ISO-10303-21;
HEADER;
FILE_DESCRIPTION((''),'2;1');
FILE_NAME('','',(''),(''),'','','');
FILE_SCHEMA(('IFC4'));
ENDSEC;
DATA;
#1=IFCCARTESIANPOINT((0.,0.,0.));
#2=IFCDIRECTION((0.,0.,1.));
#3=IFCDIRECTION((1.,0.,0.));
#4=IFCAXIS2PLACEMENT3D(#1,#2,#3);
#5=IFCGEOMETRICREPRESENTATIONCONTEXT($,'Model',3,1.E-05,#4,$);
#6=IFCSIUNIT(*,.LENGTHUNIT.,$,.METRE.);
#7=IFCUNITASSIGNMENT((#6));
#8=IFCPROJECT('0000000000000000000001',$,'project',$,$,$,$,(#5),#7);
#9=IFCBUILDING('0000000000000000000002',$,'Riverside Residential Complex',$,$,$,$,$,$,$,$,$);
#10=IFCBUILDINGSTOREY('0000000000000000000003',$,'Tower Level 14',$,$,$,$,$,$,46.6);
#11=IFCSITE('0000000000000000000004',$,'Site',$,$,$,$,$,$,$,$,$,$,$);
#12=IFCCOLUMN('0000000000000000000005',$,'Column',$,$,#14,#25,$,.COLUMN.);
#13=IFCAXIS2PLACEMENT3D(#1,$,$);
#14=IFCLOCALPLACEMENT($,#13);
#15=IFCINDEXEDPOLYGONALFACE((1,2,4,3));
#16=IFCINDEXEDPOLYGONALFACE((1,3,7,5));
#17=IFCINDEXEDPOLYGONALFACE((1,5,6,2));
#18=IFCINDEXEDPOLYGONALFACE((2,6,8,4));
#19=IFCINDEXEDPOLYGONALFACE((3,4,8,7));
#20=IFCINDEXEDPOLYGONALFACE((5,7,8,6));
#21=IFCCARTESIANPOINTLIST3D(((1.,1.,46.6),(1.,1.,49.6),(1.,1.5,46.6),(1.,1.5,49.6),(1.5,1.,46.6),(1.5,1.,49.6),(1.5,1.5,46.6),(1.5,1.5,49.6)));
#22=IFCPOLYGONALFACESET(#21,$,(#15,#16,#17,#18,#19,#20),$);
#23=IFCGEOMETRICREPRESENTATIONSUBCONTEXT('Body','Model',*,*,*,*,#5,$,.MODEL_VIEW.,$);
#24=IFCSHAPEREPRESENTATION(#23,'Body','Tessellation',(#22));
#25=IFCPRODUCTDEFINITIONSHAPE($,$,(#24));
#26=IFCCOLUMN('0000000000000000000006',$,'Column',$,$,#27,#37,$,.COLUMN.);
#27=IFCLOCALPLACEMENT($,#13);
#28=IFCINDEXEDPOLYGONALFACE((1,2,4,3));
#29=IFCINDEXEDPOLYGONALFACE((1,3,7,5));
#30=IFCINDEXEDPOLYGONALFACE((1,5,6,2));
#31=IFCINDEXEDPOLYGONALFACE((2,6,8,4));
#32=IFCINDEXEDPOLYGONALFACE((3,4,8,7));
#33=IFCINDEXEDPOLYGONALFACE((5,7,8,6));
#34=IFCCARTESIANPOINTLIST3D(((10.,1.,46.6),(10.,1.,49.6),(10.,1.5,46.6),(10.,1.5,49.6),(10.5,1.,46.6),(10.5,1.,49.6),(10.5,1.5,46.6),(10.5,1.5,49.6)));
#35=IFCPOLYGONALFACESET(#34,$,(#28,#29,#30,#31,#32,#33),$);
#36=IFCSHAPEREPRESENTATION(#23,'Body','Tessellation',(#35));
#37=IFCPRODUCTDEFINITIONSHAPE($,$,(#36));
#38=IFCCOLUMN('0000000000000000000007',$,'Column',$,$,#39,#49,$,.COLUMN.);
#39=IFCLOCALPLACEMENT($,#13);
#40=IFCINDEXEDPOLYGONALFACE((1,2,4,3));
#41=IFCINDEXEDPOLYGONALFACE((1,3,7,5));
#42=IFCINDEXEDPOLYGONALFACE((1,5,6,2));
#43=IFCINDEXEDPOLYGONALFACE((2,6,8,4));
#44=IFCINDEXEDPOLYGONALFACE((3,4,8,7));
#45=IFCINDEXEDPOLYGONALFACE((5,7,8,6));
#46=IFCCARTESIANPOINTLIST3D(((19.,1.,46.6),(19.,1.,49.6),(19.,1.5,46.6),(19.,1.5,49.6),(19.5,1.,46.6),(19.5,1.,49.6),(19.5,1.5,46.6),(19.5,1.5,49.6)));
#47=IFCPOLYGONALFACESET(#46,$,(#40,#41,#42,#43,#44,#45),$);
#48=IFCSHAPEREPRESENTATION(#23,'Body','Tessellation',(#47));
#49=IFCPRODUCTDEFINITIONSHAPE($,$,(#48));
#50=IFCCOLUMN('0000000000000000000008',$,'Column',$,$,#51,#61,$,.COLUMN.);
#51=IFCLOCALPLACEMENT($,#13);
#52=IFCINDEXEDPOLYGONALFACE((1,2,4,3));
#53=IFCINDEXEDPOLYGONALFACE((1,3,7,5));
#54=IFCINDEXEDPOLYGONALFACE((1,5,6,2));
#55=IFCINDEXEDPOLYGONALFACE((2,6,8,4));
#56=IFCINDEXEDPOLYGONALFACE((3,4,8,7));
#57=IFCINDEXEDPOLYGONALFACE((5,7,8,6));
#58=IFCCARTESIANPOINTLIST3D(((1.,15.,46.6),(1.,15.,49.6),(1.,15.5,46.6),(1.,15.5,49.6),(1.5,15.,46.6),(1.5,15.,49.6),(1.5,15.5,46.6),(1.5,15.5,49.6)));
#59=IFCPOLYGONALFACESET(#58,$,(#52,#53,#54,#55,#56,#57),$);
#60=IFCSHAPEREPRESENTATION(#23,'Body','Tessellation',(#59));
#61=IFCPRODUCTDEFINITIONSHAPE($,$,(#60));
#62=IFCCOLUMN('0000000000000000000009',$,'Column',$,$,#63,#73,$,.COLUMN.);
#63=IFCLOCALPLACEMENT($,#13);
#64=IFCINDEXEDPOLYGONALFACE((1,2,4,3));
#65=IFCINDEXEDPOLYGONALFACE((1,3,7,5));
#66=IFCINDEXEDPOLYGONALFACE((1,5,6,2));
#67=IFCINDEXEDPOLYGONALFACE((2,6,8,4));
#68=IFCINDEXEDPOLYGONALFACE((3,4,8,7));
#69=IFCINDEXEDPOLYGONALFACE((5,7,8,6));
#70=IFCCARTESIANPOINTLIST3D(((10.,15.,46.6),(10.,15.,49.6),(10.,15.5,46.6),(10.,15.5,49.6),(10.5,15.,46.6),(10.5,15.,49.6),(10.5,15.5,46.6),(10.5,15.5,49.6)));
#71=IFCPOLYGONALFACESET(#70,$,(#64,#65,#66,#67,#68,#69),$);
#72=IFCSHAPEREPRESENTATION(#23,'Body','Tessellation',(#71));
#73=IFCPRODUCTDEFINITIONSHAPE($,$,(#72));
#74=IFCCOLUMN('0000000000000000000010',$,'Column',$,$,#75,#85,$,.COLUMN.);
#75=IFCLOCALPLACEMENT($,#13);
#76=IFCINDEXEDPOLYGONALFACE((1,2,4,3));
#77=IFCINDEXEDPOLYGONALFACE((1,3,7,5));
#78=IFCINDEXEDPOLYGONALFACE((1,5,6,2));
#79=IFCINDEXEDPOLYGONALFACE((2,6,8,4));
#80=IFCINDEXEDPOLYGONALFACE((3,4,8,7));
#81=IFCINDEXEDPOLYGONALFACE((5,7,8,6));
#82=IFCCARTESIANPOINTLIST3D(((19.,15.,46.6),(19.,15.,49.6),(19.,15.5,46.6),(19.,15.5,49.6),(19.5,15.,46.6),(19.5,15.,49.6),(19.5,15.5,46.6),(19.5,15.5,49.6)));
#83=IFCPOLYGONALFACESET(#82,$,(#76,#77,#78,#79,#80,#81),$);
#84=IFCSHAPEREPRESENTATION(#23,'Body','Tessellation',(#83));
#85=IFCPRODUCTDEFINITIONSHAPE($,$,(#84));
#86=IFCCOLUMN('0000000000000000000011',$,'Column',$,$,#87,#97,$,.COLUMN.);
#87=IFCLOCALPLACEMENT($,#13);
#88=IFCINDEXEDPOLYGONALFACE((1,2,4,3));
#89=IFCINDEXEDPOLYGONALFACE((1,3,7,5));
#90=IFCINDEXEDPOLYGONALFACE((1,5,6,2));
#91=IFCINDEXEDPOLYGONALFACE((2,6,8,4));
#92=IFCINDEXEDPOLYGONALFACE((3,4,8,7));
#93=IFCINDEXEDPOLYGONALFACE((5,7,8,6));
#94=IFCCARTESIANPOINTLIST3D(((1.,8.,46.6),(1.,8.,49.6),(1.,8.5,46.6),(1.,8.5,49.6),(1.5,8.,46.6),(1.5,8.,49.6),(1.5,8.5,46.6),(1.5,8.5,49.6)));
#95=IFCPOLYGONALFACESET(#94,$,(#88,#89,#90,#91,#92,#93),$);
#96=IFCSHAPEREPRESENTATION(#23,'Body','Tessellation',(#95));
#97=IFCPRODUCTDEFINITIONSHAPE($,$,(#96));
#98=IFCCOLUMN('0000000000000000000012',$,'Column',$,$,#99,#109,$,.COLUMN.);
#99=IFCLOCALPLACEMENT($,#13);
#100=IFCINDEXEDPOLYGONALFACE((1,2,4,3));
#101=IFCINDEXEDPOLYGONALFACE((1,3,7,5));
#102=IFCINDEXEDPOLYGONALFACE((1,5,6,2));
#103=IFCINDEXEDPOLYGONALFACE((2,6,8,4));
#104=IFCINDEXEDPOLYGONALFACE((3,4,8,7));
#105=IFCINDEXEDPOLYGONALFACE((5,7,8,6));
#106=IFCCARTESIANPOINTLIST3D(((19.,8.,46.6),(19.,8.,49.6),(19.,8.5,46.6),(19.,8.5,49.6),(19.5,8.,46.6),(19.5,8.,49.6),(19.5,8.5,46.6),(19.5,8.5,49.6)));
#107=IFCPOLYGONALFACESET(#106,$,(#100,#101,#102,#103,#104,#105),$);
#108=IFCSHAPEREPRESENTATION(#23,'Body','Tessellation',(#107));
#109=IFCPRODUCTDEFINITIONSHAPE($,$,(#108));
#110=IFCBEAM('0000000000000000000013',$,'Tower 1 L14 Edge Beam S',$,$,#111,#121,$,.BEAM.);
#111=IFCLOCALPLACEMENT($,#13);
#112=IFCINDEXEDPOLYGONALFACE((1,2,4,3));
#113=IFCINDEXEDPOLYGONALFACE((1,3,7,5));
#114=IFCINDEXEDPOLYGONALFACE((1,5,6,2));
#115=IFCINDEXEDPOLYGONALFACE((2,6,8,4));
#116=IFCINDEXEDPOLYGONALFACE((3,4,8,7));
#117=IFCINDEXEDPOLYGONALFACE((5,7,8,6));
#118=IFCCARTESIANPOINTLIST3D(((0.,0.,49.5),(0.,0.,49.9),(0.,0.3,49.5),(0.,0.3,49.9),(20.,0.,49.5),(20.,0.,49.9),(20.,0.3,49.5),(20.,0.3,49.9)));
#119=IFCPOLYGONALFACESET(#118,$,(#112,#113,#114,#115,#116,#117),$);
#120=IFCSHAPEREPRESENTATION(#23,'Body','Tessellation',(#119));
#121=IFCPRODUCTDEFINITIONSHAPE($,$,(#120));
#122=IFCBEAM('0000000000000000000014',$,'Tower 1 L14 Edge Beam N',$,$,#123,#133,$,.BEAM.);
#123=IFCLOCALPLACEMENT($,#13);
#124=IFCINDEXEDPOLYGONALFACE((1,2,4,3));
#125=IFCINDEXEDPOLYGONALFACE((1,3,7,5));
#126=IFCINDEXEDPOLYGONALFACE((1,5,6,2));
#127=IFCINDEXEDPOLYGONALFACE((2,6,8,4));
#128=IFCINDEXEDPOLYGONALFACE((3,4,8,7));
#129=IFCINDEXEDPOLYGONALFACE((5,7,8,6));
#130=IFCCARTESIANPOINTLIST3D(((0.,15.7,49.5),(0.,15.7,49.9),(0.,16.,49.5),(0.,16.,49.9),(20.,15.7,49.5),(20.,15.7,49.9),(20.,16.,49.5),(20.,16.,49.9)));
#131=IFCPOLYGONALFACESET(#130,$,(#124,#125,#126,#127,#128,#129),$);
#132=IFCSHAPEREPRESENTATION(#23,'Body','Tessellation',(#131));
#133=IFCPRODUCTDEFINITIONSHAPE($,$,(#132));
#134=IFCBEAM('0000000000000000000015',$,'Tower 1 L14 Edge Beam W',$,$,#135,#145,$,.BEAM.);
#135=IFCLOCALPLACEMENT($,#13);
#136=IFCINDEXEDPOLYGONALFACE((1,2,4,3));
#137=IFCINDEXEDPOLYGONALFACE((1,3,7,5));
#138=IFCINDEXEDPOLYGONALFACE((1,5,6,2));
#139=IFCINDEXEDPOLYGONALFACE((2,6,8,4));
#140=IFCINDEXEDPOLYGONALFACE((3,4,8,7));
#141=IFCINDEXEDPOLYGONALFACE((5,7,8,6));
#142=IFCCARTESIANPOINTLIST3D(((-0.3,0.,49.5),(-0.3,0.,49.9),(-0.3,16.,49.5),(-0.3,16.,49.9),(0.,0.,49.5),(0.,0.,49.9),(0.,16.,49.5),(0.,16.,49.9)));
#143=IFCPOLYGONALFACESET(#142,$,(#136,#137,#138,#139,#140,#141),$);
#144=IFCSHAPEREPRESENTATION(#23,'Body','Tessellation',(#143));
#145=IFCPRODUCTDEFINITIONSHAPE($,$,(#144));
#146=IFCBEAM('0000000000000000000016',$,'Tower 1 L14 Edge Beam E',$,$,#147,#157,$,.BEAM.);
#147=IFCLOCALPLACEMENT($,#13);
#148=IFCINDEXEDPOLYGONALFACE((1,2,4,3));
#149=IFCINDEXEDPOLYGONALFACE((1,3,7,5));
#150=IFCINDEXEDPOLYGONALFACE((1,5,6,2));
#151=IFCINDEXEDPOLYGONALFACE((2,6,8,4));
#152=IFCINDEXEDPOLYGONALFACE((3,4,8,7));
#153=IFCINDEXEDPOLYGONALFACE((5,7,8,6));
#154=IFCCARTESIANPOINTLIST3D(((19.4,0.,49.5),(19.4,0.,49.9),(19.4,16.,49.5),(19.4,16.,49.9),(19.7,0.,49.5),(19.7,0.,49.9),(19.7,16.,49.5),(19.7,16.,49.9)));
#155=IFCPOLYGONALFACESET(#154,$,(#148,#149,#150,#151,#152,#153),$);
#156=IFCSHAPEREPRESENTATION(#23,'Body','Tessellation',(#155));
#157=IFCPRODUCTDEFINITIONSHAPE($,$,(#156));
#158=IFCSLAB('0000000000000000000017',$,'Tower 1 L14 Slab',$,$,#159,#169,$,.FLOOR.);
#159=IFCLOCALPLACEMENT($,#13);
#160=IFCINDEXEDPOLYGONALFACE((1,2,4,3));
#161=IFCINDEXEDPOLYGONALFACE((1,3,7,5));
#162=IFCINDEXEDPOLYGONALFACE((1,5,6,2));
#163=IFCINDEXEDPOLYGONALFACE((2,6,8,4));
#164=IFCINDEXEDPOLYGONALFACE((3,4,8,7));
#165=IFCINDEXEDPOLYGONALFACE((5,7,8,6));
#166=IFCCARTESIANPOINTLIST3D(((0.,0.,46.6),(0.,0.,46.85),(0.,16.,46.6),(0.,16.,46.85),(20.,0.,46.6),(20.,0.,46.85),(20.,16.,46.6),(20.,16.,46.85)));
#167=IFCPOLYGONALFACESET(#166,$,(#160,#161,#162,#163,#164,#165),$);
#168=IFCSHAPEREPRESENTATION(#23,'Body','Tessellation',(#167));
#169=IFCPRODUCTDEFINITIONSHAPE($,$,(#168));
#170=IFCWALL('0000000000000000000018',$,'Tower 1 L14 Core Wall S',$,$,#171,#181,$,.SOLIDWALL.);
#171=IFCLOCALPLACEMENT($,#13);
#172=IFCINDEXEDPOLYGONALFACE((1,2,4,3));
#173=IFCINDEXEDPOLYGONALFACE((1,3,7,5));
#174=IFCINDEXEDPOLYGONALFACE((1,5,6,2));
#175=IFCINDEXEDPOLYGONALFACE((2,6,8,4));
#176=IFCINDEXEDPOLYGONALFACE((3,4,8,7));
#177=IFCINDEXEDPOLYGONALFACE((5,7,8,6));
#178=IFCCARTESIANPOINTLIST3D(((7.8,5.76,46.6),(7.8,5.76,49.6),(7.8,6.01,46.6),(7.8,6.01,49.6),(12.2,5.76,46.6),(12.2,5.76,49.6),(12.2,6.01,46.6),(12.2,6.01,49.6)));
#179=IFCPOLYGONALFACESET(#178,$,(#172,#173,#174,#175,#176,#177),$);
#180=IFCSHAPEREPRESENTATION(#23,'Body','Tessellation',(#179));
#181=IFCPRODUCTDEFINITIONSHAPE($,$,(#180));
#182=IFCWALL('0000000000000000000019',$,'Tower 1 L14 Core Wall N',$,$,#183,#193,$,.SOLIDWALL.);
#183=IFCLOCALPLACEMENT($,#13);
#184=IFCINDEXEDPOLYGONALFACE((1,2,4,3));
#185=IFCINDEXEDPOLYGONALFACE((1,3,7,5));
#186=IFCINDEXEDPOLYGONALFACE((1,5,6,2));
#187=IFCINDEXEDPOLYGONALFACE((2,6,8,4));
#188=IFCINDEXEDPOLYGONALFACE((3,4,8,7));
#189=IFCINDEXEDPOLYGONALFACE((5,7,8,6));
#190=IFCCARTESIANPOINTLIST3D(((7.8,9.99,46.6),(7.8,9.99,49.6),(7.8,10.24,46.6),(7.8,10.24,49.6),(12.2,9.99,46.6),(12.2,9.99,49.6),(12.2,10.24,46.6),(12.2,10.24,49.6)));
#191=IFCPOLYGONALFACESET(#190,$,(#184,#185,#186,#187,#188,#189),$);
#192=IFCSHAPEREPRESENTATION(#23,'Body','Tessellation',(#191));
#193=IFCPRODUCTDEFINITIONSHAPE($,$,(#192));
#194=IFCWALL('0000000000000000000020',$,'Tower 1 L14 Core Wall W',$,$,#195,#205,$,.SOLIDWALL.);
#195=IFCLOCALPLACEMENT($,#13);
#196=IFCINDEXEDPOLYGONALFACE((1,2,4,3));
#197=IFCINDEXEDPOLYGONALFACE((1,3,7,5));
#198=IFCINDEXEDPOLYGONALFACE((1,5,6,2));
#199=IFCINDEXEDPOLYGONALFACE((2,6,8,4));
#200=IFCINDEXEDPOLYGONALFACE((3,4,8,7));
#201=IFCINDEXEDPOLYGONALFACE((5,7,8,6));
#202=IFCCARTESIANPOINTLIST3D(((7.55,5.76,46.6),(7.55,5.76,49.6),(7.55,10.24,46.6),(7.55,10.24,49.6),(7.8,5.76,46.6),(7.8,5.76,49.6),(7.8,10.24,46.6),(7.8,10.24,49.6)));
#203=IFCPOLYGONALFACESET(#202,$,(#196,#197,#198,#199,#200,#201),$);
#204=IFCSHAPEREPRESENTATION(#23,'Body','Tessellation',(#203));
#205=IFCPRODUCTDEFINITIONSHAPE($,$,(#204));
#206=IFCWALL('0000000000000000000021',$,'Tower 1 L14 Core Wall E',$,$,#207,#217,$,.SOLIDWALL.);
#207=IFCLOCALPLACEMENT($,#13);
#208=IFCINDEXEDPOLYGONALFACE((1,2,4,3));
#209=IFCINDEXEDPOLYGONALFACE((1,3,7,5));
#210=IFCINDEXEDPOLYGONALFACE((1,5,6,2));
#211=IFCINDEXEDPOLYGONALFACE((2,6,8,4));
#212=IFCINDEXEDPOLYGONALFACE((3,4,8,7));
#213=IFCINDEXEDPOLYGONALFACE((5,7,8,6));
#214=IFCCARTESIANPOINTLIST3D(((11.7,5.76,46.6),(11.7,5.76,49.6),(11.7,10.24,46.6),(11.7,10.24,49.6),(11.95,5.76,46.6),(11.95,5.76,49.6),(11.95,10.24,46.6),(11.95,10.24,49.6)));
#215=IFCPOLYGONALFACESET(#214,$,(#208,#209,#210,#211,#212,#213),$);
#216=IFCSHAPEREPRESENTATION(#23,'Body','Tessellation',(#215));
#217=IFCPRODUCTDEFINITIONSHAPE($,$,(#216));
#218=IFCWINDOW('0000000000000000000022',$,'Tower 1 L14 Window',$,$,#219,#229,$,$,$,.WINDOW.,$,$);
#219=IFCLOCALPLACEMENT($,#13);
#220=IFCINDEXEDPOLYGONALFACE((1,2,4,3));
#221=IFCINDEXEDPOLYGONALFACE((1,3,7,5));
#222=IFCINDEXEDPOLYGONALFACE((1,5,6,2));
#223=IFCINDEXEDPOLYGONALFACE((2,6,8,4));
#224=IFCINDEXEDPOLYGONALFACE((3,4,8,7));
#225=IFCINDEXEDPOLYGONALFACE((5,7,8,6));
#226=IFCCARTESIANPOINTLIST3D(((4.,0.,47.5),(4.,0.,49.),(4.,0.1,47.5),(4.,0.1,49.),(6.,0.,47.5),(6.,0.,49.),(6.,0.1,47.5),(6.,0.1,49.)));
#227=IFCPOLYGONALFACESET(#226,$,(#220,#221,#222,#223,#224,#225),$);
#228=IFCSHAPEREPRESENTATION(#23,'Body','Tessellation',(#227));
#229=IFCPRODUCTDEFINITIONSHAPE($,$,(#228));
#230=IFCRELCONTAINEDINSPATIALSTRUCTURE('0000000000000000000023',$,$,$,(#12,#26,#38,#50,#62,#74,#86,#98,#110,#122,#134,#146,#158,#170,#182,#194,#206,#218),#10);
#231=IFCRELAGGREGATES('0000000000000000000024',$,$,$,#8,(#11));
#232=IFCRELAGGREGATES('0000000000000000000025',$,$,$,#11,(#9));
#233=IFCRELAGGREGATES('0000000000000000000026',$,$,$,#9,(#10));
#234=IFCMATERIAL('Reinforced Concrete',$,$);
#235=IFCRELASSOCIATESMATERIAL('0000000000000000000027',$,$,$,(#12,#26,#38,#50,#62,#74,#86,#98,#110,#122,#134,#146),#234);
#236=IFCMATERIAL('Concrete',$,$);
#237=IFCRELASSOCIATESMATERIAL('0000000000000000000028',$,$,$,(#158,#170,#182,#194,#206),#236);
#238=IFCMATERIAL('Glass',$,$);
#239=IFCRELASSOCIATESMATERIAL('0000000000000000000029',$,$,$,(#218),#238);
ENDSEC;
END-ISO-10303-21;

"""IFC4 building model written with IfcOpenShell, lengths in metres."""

from ifc_helpers import new_model, si_unit, frame, origin_with_axes, place, context, subcontext, project, spatial, line, indexed_curve, outline, extrude, material, element, save


model = new_model("IFC4")

# Units and contexts
model_context = context("Model", 3, precision=1e-05, world=origin_with_axes())
body_context = subcontext(model_context, "Body", "Model", "MODEL_VIEW")
ifc_project = project(units=[si_unit("LENGTHUNIT", "METRE")], contexts=[model_context])

# Site, building, storey
site = spatial("IfcSite", under=ifc_project, Name="Site")
building = spatial("IfcBuilding", under=site, Name="Riverside Residential Complex")
storey = spatial("IfcBuildingStorey", under=building, Name="Tower Level 14", Elevation=46.6)

# Columns
ifc_material_1 = material(Name="Reinforced Concrete")
for number, where, z_axis, x_axis, name in (
    (1, (1.0, 1.0, 46.6), (0.0, 0.0, 1.0), (1.0, 0.0, 0.0), "Column"),
    (2, (10.0, 1.0, 46.6), (0.0, 0.0, 1.0), (1.0, 0.0, 0.0), "Column"),
    (3, (19.0, 1.0, 46.6), (0.0, 0.0, 1.0), (1.0, 0.0, 0.0), "Column"),
    (4, (1.0, 15.0, 46.6), (0.0, 0.0, 1.0), (1.0, 0.0, 0.0), "Column"),
    (5, (10.0, 15.0, 46.6), (0.0, 0.0, 1.0), (1.0, 0.0, 0.0), "Column"),
    (6, (19.0, 15.0, 46.6), (0.0, 0.0, 1.0), (1.0, 0.0, 0.0), "Column"),
    (7, (1.0, 8.0, 46.6), (0.0, 0.0, 1.0), (1.0, 0.0, 0.0), "Column"),
    (8, (19.0, 8.0, 46.6), (0.0, 0.0, 1.0), (1.0, 0.0, 0.0), "Column"),
):
    element("IfcColumn", number, at=place(None, frame(where, z_axis=z_axis, x_axis=x_axis)), inside=storey, material=ifc_material_1, Name=name, PredefinedType="COLUMN", context=body_context, shape_type="SweptSolid", body=[
        extrude(outline(indexed_curve([(0.0, 0.0), (0.5, 0.0), (0.5, 0.5), (0.0, 0.5)], segments=[line(1, 2, 3, 4, 1)])), origin_with_axes(), (0.0, 0.0, 1.0), 3.0),
    ])

# Beams
for number, where, z_axis, x_axis, name in (
    (9, (0.0, 0.0, 49.5), (0.0, 0.0, 1.0), (1.0, 0.0, 0.0), "Tower 1 L14 Edge Beam S"),
    (10, (0.0, 15.7, 49.5), (0.0, 0.0, 1.0), (1.0, 0.0, 0.0), "Tower 1 L14 Edge Beam N"),
):
    element("IfcBeam", number, at=place(None, frame(where, z_axis=z_axis, x_axis=x_axis)), inside=storey, material=ifc_material_1, Name=name, PredefinedType="BEAM", context=body_context, shape_type="SweptSolid", body=[
        extrude(outline(indexed_curve([(0.0, 0.0), (20.0, 0.0), (20.0, 0.3), (0.0, 0.3)], segments=[line(1, 2, 3, 4, 1)])), origin_with_axes(), (0.0, 0.0, 1.0), 0.4),
    ])
for number, where, z_axis, x_axis, name in (
    (11, (0.0, 0.0, 49.5), (0.0, 0.0, 1.0), (0.0, 1.0, 0.0), "Tower 1 L14 Edge Beam W"),
    (12, (19.7, 0.0, 49.5), (0.0, 0.0, 1.0), (0.0, 1.0, 0.0), "Tower 1 L14 Edge Beam E"),
):
    element("IfcBeam", number, at=place(None, frame(where, z_axis=z_axis, x_axis=x_axis)), inside=storey, material=ifc_material_1, Name=name, PredefinedType="BEAM", context=body_context, shape_type="SweptSolid", body=[
        extrude(outline(indexed_curve([(0.0, 0.0), (16.0, 0.0), (16.0, 0.3), (0.0, 0.3)], segments=[line(1, 2, 3, 4, 1)])), origin_with_axes(), (0.0, 0.0, 1.0), 0.4),
    ])

# Slab
ifc_material_2 = material(Name="Concrete")
slab_placement = place(None, frame((0.0, 0.0, 46.6), z_axis=(0.0, 0.0, 1.0), x_axis=(1.0, 0.0, 0.0)))
element("IfcSlab", 13, at=slab_placement, inside=storey, material=ifc_material_2, Name="Tower 1 L14 Slab", PredefinedType="FLOOR", context=body_context, shape_type="SweptSolid", body=[
    extrude(outline(indexed_curve([(0.0, 0.0), (20.0, 0.0), (20.0, 16.0), (0.0, 16.0)], segments=[line(1, 2, 3, 4, 1)])), origin_with_axes(), (0.0, 0.0, 1.0), 0.25),
])

# Walls
for number, where, z_axis, x_axis, name in (
    (14, (7.8, 5.76, 46.6), (0.0, 0.0, 1.0), (1.0, 0.0, 0.0), "Tower 1 L14 Core Wall S"),
    (15, (7.8, 9.99, 46.6), (0.0, 0.0, 1.0), (1.0, 0.0, 0.0), "Tower 1 L14 Core Wall N"),
):
    element("IfcWall", number, at=place(None, frame(where, z_axis=z_axis, x_axis=x_axis)), inside=storey, material=ifc_material_2, Name=name, PredefinedType="SOLIDWALL", context=body_context, shape_type="SweptSolid", body=[
        extrude(outline(indexed_curve([(0.0, 0.0), (4.4, 0.0), (4.4, 0.25), (0.0, 0.25)], segments=[line(1, 2, 3, 4, 1)])), origin_with_axes(), (0.0, 0.0, 1.0), 3.0),
    ])
for number, where, z_axis, x_axis, name in (
    (16, (7.8, 5.76, 46.6), (0.0, 0.0, 1.0), (0.0, 1.0, 0.0), "Tower 1 L14 Core Wall W"),
    (17, (11.95, 5.76, 46.6), (0.0, 0.0, 1.0), (0.0, 1.0, 0.0), "Tower 1 L14 Core Wall E"),
):
    element("IfcWall", number, at=place(None, frame(where, z_axis=z_axis, x_axis=x_axis)), inside=storey, material=ifc_material_2, Name=name, PredefinedType="SOLIDWALL", context=body_context, shape_type="SweptSolid", body=[
        extrude(outline(indexed_curve([(0.0, 0.0), (4.48, 0.0), (4.48, 0.25), (0.0, 0.25)], segments=[line(1, 2, 3, 4, 1)])), origin_with_axes(), (0.0, 0.0, 1.0), 3.0),
    ])

# Window
ifc_material_3 = material(Name="Glass")
for number, where, z_axis, x_axis, name in (
    (18, (4.0, 0.0, 47.5), (0.0, 0.0, 1.0), (1.0, 0.0, 0.0), "Tower 1 L14 Window"),
):
    element("IfcWindow", number, at=place(None, frame(where, z_axis=z_axis, x_axis=x_axis)), inside=storey, material=ifc_material_3, Name=name, PredefinedType="WINDOW", context=body_context, shape_type="SweptSolid", body=[
        extrude(outline(indexed_curve([(0.0, 0.0), (2.0, 0.0), (2.0, 0.1), (0.0, 0.1)], segments=[line(1, 2, 3, 4, 1)])), origin_with_axes(), (0.0, 0.0, 1.0), 1.5),
    ])

save(model, "model.ifc")
